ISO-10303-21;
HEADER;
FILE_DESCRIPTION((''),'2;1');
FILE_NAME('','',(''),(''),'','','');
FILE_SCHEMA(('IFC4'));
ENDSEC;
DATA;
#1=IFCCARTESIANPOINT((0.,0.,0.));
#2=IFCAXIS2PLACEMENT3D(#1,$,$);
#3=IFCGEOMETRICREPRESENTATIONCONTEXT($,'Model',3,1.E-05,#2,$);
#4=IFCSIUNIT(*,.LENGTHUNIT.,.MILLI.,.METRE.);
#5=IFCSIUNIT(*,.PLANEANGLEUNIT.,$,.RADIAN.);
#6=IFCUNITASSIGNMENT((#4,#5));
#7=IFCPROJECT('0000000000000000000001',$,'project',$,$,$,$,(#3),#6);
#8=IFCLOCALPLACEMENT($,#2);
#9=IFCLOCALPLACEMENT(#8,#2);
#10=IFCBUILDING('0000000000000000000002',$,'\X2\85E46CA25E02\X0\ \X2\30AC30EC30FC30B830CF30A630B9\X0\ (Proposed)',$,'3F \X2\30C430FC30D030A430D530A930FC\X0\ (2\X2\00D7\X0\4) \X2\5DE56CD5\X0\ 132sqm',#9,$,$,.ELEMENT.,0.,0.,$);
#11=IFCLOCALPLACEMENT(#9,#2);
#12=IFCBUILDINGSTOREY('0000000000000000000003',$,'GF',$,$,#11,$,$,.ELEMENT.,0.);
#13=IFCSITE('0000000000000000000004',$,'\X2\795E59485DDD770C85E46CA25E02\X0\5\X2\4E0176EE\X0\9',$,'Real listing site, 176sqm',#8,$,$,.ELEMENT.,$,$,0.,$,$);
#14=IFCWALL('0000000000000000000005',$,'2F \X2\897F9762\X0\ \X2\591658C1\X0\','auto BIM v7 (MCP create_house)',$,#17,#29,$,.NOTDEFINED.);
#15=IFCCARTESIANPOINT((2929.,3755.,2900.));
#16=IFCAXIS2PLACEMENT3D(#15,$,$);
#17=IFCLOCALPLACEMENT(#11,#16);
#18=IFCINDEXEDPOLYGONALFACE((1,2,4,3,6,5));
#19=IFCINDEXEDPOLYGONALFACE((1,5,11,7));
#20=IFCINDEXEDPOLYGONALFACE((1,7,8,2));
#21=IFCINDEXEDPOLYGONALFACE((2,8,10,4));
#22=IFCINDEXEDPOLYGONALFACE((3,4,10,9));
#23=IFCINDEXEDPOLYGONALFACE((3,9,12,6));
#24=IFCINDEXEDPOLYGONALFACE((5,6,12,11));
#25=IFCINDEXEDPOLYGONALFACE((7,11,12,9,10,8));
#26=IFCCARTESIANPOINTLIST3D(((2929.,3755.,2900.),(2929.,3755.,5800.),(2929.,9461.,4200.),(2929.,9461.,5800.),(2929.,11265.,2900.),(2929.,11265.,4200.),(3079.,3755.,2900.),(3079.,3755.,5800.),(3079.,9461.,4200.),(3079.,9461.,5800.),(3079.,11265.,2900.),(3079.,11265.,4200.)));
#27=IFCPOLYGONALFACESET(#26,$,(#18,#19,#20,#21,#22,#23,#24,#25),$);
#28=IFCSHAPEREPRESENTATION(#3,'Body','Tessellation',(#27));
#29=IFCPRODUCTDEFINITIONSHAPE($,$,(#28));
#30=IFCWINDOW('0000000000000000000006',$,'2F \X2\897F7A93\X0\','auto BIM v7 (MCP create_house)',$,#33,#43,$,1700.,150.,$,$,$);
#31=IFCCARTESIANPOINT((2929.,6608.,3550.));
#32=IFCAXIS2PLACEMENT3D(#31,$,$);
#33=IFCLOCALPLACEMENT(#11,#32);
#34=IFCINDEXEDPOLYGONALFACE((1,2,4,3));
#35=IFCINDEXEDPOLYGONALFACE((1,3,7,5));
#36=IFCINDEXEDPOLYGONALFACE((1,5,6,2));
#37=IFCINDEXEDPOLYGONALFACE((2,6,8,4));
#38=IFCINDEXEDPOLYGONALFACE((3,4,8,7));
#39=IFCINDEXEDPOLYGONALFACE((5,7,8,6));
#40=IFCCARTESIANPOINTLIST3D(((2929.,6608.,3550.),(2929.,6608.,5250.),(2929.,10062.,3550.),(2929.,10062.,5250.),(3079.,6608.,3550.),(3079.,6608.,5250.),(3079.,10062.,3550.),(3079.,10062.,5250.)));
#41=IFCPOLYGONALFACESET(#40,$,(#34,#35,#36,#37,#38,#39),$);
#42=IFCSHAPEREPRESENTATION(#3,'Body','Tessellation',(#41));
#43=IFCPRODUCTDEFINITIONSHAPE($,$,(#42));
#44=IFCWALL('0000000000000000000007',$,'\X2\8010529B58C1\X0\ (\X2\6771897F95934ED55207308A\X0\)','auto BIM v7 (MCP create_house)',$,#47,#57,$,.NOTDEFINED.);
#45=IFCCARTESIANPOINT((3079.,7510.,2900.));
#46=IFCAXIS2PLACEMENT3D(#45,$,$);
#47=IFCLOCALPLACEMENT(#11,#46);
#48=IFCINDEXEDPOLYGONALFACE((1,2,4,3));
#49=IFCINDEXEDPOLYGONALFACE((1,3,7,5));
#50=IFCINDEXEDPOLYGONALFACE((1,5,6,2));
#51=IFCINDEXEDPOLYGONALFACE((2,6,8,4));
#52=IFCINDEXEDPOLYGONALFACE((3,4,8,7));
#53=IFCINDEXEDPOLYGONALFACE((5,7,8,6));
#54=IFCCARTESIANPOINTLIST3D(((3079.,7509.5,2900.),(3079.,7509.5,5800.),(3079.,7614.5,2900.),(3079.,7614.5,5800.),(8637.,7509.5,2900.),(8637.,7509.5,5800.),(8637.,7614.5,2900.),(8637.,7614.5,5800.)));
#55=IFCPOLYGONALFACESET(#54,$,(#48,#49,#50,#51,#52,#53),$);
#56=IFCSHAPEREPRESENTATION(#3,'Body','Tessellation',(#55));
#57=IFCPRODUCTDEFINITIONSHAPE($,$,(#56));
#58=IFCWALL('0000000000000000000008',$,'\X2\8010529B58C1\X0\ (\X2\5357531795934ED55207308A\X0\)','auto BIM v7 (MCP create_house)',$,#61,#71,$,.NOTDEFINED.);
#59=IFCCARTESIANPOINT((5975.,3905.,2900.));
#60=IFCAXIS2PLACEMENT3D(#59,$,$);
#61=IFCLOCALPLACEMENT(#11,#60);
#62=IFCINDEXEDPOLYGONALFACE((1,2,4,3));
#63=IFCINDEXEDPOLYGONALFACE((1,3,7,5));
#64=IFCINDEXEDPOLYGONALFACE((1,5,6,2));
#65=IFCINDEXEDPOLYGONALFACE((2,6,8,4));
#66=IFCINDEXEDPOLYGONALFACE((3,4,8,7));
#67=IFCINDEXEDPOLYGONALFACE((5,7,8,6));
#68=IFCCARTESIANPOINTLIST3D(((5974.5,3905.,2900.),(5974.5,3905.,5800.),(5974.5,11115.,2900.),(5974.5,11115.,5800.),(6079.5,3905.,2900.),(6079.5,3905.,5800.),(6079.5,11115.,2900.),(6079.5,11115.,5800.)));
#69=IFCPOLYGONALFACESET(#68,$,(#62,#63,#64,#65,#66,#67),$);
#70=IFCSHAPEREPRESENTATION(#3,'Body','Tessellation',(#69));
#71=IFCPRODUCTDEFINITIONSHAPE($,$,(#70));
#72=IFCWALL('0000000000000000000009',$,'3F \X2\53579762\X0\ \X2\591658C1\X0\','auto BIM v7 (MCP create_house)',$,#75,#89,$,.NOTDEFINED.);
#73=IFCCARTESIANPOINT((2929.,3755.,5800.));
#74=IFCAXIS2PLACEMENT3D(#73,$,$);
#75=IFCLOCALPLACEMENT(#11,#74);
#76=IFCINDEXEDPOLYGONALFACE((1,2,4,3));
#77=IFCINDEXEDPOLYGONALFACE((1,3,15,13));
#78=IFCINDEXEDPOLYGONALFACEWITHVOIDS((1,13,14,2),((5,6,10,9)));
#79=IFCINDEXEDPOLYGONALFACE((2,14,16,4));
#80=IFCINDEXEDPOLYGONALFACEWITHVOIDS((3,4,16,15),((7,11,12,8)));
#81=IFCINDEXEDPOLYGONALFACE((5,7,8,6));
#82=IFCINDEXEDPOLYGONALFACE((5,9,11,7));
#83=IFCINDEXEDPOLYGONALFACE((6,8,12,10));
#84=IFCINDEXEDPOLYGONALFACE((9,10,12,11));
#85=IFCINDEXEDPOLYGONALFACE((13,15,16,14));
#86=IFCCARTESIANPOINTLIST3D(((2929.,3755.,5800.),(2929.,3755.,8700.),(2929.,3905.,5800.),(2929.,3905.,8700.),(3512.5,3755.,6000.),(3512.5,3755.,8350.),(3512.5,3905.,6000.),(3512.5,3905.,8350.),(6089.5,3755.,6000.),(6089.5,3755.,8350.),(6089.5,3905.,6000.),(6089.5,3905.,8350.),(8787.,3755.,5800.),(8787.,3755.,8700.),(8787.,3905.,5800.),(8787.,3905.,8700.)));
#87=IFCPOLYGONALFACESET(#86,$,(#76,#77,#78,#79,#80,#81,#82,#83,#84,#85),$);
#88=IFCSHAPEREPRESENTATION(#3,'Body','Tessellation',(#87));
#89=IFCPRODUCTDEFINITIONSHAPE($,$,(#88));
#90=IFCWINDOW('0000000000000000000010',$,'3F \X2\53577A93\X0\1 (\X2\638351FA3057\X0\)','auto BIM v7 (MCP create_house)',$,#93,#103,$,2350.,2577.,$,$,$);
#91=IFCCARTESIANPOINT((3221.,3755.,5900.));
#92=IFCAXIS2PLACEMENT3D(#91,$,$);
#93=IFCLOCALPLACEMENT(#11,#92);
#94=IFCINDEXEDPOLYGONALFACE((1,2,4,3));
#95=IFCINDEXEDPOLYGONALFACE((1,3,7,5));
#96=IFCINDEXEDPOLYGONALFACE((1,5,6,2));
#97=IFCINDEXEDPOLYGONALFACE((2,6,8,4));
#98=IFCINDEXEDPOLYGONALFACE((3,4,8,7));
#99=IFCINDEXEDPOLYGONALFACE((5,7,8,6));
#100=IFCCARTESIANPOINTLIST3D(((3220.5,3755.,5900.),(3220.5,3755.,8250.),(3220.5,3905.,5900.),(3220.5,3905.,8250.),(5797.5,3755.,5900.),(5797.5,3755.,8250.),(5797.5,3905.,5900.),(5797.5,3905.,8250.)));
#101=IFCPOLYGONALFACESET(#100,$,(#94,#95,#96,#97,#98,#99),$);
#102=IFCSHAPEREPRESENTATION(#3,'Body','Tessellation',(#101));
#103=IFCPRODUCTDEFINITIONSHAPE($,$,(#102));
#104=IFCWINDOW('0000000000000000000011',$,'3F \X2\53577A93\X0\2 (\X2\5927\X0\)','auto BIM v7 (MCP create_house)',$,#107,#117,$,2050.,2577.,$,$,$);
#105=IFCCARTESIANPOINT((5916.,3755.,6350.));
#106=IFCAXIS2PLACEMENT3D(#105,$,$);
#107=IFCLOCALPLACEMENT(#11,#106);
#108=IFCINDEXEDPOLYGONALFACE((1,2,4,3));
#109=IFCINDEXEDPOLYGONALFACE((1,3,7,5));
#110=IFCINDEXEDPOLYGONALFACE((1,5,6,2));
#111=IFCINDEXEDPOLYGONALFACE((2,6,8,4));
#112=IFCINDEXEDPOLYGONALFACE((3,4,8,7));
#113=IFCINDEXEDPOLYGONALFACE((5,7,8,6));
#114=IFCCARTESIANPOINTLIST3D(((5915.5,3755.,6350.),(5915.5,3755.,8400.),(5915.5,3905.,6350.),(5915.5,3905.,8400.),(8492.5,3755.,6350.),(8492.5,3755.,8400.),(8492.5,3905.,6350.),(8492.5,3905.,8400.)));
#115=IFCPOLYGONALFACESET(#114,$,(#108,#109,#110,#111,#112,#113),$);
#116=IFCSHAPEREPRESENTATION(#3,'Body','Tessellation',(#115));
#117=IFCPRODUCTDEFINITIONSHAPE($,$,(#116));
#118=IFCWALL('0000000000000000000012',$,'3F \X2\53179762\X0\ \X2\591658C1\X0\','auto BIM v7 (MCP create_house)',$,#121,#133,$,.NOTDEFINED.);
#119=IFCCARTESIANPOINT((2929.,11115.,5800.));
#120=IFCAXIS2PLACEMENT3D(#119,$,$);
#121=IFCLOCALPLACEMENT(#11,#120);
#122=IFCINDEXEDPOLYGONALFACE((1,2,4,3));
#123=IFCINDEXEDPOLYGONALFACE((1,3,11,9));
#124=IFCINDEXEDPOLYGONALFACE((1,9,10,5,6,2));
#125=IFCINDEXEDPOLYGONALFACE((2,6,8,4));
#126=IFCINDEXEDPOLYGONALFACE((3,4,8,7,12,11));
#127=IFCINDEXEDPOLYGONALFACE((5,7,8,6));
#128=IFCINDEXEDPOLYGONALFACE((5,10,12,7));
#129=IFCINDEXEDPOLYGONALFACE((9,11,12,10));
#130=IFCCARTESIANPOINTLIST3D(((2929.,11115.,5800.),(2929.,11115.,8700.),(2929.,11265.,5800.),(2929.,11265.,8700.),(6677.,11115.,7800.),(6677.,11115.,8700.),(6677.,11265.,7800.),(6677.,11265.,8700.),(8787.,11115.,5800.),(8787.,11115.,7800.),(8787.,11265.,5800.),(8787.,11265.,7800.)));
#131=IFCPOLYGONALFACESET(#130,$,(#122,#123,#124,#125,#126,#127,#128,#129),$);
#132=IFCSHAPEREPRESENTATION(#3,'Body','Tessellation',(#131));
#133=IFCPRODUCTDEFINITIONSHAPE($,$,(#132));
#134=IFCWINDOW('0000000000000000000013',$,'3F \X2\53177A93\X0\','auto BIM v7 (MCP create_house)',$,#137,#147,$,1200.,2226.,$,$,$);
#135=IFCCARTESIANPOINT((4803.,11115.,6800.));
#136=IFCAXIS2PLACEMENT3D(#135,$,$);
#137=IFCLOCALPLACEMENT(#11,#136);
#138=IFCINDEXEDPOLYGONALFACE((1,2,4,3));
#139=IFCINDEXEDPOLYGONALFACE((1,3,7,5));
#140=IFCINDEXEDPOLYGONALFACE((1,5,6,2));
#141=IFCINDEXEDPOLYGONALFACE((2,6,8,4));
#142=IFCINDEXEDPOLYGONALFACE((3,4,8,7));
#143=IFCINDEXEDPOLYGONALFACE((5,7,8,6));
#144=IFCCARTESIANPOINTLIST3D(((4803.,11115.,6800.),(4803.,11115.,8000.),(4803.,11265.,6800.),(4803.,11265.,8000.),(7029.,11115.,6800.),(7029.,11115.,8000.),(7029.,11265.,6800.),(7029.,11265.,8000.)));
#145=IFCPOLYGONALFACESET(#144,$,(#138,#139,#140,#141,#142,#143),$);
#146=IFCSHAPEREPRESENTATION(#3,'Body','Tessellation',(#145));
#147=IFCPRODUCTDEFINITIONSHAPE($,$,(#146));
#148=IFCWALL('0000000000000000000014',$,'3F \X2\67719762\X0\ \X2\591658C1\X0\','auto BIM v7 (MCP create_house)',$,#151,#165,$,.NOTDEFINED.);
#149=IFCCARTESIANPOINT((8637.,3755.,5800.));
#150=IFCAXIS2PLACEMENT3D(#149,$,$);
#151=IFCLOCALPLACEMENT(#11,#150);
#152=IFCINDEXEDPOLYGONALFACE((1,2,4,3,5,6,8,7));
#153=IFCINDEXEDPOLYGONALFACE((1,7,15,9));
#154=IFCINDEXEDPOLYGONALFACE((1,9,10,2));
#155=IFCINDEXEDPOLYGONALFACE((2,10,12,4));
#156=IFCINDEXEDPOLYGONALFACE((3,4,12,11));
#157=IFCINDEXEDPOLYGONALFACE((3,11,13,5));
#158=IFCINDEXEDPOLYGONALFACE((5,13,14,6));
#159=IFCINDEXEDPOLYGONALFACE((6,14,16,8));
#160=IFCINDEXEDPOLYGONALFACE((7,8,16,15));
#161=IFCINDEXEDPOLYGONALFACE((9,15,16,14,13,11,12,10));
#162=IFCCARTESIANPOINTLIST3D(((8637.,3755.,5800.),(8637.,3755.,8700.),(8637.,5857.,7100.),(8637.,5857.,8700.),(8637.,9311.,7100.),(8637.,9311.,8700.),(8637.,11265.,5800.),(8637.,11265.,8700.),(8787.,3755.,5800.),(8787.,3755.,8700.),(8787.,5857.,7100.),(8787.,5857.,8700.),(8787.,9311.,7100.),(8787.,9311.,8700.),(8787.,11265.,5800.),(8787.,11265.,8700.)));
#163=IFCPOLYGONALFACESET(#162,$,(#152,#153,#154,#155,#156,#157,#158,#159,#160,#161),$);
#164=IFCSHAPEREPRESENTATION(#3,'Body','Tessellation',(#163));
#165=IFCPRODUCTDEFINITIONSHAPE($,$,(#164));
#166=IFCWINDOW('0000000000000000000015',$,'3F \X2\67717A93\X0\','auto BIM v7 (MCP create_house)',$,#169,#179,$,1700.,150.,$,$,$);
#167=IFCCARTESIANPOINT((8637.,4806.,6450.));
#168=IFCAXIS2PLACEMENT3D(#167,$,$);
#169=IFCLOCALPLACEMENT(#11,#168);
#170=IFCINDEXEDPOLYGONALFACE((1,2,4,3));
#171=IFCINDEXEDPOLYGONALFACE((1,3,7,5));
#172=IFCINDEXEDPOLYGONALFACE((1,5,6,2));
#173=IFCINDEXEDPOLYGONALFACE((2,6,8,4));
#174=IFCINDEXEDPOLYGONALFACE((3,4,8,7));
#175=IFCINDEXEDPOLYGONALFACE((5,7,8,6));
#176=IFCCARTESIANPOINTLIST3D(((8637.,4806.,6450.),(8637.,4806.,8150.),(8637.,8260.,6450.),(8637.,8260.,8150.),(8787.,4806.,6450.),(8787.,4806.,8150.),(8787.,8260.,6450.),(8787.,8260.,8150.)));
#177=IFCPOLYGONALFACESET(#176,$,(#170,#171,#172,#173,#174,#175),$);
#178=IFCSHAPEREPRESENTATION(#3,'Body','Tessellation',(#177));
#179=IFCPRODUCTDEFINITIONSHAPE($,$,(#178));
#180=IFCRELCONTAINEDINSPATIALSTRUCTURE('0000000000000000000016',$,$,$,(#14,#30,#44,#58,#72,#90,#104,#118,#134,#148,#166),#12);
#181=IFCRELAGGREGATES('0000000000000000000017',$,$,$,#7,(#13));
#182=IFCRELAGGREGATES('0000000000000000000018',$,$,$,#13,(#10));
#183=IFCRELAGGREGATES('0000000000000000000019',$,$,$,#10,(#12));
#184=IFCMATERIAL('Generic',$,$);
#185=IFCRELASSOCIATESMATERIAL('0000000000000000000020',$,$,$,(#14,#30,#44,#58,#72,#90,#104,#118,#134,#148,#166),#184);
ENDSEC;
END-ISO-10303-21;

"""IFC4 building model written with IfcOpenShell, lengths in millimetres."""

from ifc_helpers import new_model, si_unit, frame, frame_2d, origin, place, context, project, spatial, rectangle, extrude, material, element, fill, save


model = new_model("IFC4")

# Units and contexts
model_context = context("Model", 3, precision=1e-05, world=origin())
ifc_project = project(units=[si_unit("LENGTHUNIT", "METRE", prefix="MILLI"), si_unit("PLANEANGLEUNIT", "RADIAN")], contexts=[model_context])

# Site, building, storey
site_placement = place(None, origin())
site = spatial("IfcSite", under=ifc_project, at=site_placement, Name="神奈川県藤沢市5丁目9", ObjectType="Real listing site, 176sqm", CompositionType="ELEMENT", RefElevation=0.0)
building_placement = place(site_placement, origin())
building = spatial("IfcBuilding", under=site, at=building_placement, Name="藤沢市 ガレージハウス (Proposed)", ObjectType="3F ツーバイフォー (2×4) 工法 132sqm", CompositionType="ELEMENT", ElevationOfRefHeight=0.0, ElevationOfTerrain=0.0)
storey_placement = place(building_placement, origin())
storey = spatial("IfcBuildingStorey", under=building, at=storey_placement, Name="GF", CompositionType="ELEMENT", Elevation=0.0)

# Shared definitions
ifc_material = material(Name="Generic")

# Wall, opening, window
wall_1_placement = place(storey_placement, frame((2929.0, 3755.0, 2900.0)))
wall_1 = element("IfcWall", 1, at=wall_1_placement, inside=storey, material=ifc_material, Name="2F 西面 外壁", Description="auto BIM v7 (MCP create_house)", PredefinedType="NOTDEFINED", context=model_context, shape_type="SweptSolid", body=[
    extrude(rectangle(XDim=150.0, YDim=7510.0, at=frame_2d((75.0, 3755.0))), frame((2929.0, 3755.0, 2900.0)), (0.0, 0.0, 1.0), 2900.0),
])
opening_1_placement = place(storey_placement, frame((2929.0, 6608.0, 3550.0)))
opening_1 = element("IfcOpeningElement", 2, at=opening_1_placement, cuts=wall_1, PredefinedType="NOTDEFINED", context=model_context, shape_type="SweptSolid", body=[
    extrude(rectangle(XDim=150.0, YDim=3454.0, at=frame_2d((75.0, 1727.0))), frame((2929.0, 6608.0, 3550.0)), (0.0, 0.0, 1.0), 1700.0),
])
window_1_placement = place(storey_placement, frame((2929.0, 6608.0, 3550.0)))
window_1 = element("IfcWindow", 3, at=window_1_placement, inside=storey, material=ifc_material, Name="2F 西窓", Description="auto BIM v7 (MCP create_house)", OverallHeight=1700.0, OverallWidth=150.0, context=model_context, shape_type="SweptSolid", body=[
    extrude(rectangle(XDim=150.0, YDim=3454.0, at=frame_2d((75.0, 1727.0))), frame((2929.0, 6608.0, 3550.0)), (0.0, 0.0, 1.0), 1700.0),
])
fill(opening_1, window_1)

# Walls
wall_2_placement = place(storey_placement, frame((3079.0, 7510.0, 2900.0)))
element("IfcWall", 4, at=wall_2_placement, inside=storey, material=ifc_material, Name="耐力壁 (東西間仕切り)", Description="auto BIM v7 (MCP create_house)", PredefinedType="NOTDEFINED", context=model_context, shape_type="SweptSolid", body=[
    extrude(rectangle(XDim=5558.0, YDim=105.0, at=frame_2d((2779.0, 52.0))), frame((3079.0, 7510.0, 2900.0)), (0.0, 0.0, 1.0), 2900.0),
])
wall_3_placement = place(storey_placement, frame((5975.0, 3905.0, 2900.0)))
element("IfcWall", 5, at=wall_3_placement, inside=storey, material=ifc_material, Name="耐力壁 (南北間仕切り)", Description="auto BIM v7 (MCP create_house)", PredefinedType="NOTDEFINED", context=model_context, shape_type="SweptSolid", body=[
    extrude(rectangle(XDim=105.0, YDim=7210.0, at=frame_2d((52.0, 3605.0))), frame((5975.0, 3905.0, 2900.0)), (0.0, 0.0, 1.0), 2900.0),
])

# Wall, openings, windows
wall_4_placement = place(storey_placement, frame((2929.0, 3755.0, 5800.0)))
wall_4 = element("IfcWall", 6, at=wall_4_placement, inside=storey, material=ifc_material, Name="3F 南面 外壁", Description="auto BIM v7 (MCP create_house)", PredefinedType="NOTDEFINED", context=model_context, shape_type="SweptSolid", body=[
    extrude(rectangle(XDim=5858.0, YDim=150.0, at=frame_2d((2929.0, 75.0))), frame((2929.0, 3755.0, 5800.0)), (0.0, 0.0, 1.0), 2900.0),
])
opening_2_placement = place(storey_placement, frame((3221.0, 3755.0, 5900.0)))
opening_2 = element("IfcOpeningElement", 7, at=opening_2_placement, cuts=wall_4, PredefinedType="NOTDEFINED", context=model_context, shape_type="SweptSolid", body=[
    extrude(rectangle(XDim=2577.0, YDim=150.0, at=frame_2d((1288.0, 75.0))), frame((3221.0, 3755.0, 5900.0)), (0.0, 0.0, 1.0), 2350.0),
])
opening_3_placement = place(storey_placement, frame((5916.0, 3755.0, 6350.0)))
opening_3 = element("IfcOpeningElement", 8, at=opening_3_placement, cuts=wall_4, PredefinedType="NOTDEFINED", context=model_context, shape_type="SweptSolid", body=[
    extrude(rectangle(XDim=2577.0, YDim=150.0, at=frame_2d((1288.0, 75.0))), frame((5916.0, 3755.0, 6350.0)), (0.0, 0.0, 1.0), 2050.0),
])
window_2_placement = place(storey_placement, frame((3221.0, 3755.0, 5900.0)))
window_2 = element("IfcWindow", 9, at=window_2_placement, inside=storey, material=ifc_material, Name="3F 南窓1 (掃出し)", Description="auto BIM v7 (MCP create_house)", OverallHeight=2350.0, OverallWidth=2577.0, context=model_context, shape_type="SweptSolid", body=[
    extrude(rectangle(XDim=2577.0, YDim=150.0, at=frame_2d((1288.0, 75.0))), frame((3221.0, 3755.0, 5900.0)), (0.0, 0.0, 1.0), 2350.0),
])
fill(opening_2, window_2)
window_3_placement = place(storey_placement, frame((5916.0, 3755.0, 6350.0)))
window_3 = element("IfcWindow", 10, at=window_3_placement, inside=storey, material=ifc_material, Name="3F 南窓2 (大)", Description="auto BIM v7 (MCP create_house)", OverallHeight=2050.0, OverallWidth=2577.0, context=model_context, shape_type="SweptSolid", body=[
    extrude(rectangle(XDim=2577.0, YDim=150.0, at=frame_2d((1288.0, 75.0))), frame((5916.0, 3755.0, 6350.0)), (0.0, 0.0, 1.0), 2050.0),
])
fill(opening_3, window_3)

# Walls, openings, windows
wall_5_placement = place(storey_placement, frame((2929.0, 11115.0, 5800.0)))
wall_5 = element("IfcWall", 11, at=wall_5_placement, inside=storey, material=ifc_material, Name="3F 北面 外壁", Description="auto BIM v7 (MCP create_house)", PredefinedType="NOTDEFINED", context=model_context, shape_type="SweptSolid", body=[
    extrude(rectangle(XDim=5858.0, YDim=150.0, at=frame_2d((2929.0, 75.0))), frame((2929.0, 11115.0, 5800.0)), (0.0, 0.0, 1.0), 2900.0),
])
opening_4_placement = place(storey_placement, frame((4803.0, 11115.0, 6800.0)))
opening_4 = element("IfcOpeningElement", 12, at=opening_4_placement, cuts=wall_5, PredefinedType="NOTDEFINED", context=model_context, shape_type="SweptSolid", body=[
    extrude(rectangle(XDim=2226.0, YDim=150.0, at=frame_2d((1113.0, 75.0))), frame((4803.0, 11115.0, 6800.0)), (0.0, 0.0, 1.0), 1200.0),
])
window_4_placement = place(storey_placement, frame((4803.0, 11115.0, 6800.0)))
window_4 = element("IfcWindow", 13, at=window_4_placement, inside=storey, material=ifc_material, Name="3F 北窓", Description="auto BIM v7 (MCP create_house)", OverallHeight=1200.0, OverallWidth=2226.0, context=model_context, shape_type="SweptSolid", body=[
    extrude(rectangle(XDim=2226.0, YDim=150.0, at=frame_2d((1113.0, 75.0))), frame((4803.0, 11115.0, 6800.0)), (0.0, 0.0, 1.0), 1200.0),
])
fill(opening_4, window_4)
wall_6_placement = place(storey_placement, frame((8637.0, 3755.0, 5800.0)))
wall_6 = element("IfcWall", 14, at=wall_6_placement, inside=storey, material=ifc_material, Name="3F 東面 外壁", Description="auto BIM v7 (MCP create_house)", PredefinedType="NOTDEFINED", context=model_context, shape_type="SweptSolid", body=[
    extrude(rectangle(XDim=150.0, YDim=7510.0, at=frame_2d((75.0, 3755.0))), frame((8637.0, 3755.0, 5800.0)), (0.0, 0.0, 1.0), 2900.0),
])
opening_5_placement = place(storey_placement, frame((8637.0, 4806.0, 6450.0)))
opening_5 = element("IfcOpeningElement", 15, at=opening_5_placement, cuts=wall_6, PredefinedType="NOTDEFINED", context=model_context, shape_type="SweptSolid", body=[
    extrude(rectangle(XDim=150.0, YDim=3454.0, at=frame_2d((75.0, 1727.0))), frame((8637.0, 4806.0, 6450.0)), (0.0, 0.0, 1.0), 1700.0),
])
window_5_placement = place(storey_placement, frame((8637.0, 4806.0, 6450.0)))
window_5 = element("IfcWindow", 16, at=window_5_placement, inside=storey, material=ifc_material, Name="3F 東窓", Description="auto BIM v7 (MCP create_house)", OverallHeight=1700.0, OverallWidth=150.0, context=model_context, shape_type="SweptSolid", body=[
    extrude(rectangle(XDim=150.0, YDim=3454.0, at=frame_2d((75.0, 1727.0))), frame((8637.0, 4806.0, 6450.0)), (0.0, 0.0, 1.0), 1700.0),
])
fill(opening_5, window_5)

save(model, "model.ifc")
